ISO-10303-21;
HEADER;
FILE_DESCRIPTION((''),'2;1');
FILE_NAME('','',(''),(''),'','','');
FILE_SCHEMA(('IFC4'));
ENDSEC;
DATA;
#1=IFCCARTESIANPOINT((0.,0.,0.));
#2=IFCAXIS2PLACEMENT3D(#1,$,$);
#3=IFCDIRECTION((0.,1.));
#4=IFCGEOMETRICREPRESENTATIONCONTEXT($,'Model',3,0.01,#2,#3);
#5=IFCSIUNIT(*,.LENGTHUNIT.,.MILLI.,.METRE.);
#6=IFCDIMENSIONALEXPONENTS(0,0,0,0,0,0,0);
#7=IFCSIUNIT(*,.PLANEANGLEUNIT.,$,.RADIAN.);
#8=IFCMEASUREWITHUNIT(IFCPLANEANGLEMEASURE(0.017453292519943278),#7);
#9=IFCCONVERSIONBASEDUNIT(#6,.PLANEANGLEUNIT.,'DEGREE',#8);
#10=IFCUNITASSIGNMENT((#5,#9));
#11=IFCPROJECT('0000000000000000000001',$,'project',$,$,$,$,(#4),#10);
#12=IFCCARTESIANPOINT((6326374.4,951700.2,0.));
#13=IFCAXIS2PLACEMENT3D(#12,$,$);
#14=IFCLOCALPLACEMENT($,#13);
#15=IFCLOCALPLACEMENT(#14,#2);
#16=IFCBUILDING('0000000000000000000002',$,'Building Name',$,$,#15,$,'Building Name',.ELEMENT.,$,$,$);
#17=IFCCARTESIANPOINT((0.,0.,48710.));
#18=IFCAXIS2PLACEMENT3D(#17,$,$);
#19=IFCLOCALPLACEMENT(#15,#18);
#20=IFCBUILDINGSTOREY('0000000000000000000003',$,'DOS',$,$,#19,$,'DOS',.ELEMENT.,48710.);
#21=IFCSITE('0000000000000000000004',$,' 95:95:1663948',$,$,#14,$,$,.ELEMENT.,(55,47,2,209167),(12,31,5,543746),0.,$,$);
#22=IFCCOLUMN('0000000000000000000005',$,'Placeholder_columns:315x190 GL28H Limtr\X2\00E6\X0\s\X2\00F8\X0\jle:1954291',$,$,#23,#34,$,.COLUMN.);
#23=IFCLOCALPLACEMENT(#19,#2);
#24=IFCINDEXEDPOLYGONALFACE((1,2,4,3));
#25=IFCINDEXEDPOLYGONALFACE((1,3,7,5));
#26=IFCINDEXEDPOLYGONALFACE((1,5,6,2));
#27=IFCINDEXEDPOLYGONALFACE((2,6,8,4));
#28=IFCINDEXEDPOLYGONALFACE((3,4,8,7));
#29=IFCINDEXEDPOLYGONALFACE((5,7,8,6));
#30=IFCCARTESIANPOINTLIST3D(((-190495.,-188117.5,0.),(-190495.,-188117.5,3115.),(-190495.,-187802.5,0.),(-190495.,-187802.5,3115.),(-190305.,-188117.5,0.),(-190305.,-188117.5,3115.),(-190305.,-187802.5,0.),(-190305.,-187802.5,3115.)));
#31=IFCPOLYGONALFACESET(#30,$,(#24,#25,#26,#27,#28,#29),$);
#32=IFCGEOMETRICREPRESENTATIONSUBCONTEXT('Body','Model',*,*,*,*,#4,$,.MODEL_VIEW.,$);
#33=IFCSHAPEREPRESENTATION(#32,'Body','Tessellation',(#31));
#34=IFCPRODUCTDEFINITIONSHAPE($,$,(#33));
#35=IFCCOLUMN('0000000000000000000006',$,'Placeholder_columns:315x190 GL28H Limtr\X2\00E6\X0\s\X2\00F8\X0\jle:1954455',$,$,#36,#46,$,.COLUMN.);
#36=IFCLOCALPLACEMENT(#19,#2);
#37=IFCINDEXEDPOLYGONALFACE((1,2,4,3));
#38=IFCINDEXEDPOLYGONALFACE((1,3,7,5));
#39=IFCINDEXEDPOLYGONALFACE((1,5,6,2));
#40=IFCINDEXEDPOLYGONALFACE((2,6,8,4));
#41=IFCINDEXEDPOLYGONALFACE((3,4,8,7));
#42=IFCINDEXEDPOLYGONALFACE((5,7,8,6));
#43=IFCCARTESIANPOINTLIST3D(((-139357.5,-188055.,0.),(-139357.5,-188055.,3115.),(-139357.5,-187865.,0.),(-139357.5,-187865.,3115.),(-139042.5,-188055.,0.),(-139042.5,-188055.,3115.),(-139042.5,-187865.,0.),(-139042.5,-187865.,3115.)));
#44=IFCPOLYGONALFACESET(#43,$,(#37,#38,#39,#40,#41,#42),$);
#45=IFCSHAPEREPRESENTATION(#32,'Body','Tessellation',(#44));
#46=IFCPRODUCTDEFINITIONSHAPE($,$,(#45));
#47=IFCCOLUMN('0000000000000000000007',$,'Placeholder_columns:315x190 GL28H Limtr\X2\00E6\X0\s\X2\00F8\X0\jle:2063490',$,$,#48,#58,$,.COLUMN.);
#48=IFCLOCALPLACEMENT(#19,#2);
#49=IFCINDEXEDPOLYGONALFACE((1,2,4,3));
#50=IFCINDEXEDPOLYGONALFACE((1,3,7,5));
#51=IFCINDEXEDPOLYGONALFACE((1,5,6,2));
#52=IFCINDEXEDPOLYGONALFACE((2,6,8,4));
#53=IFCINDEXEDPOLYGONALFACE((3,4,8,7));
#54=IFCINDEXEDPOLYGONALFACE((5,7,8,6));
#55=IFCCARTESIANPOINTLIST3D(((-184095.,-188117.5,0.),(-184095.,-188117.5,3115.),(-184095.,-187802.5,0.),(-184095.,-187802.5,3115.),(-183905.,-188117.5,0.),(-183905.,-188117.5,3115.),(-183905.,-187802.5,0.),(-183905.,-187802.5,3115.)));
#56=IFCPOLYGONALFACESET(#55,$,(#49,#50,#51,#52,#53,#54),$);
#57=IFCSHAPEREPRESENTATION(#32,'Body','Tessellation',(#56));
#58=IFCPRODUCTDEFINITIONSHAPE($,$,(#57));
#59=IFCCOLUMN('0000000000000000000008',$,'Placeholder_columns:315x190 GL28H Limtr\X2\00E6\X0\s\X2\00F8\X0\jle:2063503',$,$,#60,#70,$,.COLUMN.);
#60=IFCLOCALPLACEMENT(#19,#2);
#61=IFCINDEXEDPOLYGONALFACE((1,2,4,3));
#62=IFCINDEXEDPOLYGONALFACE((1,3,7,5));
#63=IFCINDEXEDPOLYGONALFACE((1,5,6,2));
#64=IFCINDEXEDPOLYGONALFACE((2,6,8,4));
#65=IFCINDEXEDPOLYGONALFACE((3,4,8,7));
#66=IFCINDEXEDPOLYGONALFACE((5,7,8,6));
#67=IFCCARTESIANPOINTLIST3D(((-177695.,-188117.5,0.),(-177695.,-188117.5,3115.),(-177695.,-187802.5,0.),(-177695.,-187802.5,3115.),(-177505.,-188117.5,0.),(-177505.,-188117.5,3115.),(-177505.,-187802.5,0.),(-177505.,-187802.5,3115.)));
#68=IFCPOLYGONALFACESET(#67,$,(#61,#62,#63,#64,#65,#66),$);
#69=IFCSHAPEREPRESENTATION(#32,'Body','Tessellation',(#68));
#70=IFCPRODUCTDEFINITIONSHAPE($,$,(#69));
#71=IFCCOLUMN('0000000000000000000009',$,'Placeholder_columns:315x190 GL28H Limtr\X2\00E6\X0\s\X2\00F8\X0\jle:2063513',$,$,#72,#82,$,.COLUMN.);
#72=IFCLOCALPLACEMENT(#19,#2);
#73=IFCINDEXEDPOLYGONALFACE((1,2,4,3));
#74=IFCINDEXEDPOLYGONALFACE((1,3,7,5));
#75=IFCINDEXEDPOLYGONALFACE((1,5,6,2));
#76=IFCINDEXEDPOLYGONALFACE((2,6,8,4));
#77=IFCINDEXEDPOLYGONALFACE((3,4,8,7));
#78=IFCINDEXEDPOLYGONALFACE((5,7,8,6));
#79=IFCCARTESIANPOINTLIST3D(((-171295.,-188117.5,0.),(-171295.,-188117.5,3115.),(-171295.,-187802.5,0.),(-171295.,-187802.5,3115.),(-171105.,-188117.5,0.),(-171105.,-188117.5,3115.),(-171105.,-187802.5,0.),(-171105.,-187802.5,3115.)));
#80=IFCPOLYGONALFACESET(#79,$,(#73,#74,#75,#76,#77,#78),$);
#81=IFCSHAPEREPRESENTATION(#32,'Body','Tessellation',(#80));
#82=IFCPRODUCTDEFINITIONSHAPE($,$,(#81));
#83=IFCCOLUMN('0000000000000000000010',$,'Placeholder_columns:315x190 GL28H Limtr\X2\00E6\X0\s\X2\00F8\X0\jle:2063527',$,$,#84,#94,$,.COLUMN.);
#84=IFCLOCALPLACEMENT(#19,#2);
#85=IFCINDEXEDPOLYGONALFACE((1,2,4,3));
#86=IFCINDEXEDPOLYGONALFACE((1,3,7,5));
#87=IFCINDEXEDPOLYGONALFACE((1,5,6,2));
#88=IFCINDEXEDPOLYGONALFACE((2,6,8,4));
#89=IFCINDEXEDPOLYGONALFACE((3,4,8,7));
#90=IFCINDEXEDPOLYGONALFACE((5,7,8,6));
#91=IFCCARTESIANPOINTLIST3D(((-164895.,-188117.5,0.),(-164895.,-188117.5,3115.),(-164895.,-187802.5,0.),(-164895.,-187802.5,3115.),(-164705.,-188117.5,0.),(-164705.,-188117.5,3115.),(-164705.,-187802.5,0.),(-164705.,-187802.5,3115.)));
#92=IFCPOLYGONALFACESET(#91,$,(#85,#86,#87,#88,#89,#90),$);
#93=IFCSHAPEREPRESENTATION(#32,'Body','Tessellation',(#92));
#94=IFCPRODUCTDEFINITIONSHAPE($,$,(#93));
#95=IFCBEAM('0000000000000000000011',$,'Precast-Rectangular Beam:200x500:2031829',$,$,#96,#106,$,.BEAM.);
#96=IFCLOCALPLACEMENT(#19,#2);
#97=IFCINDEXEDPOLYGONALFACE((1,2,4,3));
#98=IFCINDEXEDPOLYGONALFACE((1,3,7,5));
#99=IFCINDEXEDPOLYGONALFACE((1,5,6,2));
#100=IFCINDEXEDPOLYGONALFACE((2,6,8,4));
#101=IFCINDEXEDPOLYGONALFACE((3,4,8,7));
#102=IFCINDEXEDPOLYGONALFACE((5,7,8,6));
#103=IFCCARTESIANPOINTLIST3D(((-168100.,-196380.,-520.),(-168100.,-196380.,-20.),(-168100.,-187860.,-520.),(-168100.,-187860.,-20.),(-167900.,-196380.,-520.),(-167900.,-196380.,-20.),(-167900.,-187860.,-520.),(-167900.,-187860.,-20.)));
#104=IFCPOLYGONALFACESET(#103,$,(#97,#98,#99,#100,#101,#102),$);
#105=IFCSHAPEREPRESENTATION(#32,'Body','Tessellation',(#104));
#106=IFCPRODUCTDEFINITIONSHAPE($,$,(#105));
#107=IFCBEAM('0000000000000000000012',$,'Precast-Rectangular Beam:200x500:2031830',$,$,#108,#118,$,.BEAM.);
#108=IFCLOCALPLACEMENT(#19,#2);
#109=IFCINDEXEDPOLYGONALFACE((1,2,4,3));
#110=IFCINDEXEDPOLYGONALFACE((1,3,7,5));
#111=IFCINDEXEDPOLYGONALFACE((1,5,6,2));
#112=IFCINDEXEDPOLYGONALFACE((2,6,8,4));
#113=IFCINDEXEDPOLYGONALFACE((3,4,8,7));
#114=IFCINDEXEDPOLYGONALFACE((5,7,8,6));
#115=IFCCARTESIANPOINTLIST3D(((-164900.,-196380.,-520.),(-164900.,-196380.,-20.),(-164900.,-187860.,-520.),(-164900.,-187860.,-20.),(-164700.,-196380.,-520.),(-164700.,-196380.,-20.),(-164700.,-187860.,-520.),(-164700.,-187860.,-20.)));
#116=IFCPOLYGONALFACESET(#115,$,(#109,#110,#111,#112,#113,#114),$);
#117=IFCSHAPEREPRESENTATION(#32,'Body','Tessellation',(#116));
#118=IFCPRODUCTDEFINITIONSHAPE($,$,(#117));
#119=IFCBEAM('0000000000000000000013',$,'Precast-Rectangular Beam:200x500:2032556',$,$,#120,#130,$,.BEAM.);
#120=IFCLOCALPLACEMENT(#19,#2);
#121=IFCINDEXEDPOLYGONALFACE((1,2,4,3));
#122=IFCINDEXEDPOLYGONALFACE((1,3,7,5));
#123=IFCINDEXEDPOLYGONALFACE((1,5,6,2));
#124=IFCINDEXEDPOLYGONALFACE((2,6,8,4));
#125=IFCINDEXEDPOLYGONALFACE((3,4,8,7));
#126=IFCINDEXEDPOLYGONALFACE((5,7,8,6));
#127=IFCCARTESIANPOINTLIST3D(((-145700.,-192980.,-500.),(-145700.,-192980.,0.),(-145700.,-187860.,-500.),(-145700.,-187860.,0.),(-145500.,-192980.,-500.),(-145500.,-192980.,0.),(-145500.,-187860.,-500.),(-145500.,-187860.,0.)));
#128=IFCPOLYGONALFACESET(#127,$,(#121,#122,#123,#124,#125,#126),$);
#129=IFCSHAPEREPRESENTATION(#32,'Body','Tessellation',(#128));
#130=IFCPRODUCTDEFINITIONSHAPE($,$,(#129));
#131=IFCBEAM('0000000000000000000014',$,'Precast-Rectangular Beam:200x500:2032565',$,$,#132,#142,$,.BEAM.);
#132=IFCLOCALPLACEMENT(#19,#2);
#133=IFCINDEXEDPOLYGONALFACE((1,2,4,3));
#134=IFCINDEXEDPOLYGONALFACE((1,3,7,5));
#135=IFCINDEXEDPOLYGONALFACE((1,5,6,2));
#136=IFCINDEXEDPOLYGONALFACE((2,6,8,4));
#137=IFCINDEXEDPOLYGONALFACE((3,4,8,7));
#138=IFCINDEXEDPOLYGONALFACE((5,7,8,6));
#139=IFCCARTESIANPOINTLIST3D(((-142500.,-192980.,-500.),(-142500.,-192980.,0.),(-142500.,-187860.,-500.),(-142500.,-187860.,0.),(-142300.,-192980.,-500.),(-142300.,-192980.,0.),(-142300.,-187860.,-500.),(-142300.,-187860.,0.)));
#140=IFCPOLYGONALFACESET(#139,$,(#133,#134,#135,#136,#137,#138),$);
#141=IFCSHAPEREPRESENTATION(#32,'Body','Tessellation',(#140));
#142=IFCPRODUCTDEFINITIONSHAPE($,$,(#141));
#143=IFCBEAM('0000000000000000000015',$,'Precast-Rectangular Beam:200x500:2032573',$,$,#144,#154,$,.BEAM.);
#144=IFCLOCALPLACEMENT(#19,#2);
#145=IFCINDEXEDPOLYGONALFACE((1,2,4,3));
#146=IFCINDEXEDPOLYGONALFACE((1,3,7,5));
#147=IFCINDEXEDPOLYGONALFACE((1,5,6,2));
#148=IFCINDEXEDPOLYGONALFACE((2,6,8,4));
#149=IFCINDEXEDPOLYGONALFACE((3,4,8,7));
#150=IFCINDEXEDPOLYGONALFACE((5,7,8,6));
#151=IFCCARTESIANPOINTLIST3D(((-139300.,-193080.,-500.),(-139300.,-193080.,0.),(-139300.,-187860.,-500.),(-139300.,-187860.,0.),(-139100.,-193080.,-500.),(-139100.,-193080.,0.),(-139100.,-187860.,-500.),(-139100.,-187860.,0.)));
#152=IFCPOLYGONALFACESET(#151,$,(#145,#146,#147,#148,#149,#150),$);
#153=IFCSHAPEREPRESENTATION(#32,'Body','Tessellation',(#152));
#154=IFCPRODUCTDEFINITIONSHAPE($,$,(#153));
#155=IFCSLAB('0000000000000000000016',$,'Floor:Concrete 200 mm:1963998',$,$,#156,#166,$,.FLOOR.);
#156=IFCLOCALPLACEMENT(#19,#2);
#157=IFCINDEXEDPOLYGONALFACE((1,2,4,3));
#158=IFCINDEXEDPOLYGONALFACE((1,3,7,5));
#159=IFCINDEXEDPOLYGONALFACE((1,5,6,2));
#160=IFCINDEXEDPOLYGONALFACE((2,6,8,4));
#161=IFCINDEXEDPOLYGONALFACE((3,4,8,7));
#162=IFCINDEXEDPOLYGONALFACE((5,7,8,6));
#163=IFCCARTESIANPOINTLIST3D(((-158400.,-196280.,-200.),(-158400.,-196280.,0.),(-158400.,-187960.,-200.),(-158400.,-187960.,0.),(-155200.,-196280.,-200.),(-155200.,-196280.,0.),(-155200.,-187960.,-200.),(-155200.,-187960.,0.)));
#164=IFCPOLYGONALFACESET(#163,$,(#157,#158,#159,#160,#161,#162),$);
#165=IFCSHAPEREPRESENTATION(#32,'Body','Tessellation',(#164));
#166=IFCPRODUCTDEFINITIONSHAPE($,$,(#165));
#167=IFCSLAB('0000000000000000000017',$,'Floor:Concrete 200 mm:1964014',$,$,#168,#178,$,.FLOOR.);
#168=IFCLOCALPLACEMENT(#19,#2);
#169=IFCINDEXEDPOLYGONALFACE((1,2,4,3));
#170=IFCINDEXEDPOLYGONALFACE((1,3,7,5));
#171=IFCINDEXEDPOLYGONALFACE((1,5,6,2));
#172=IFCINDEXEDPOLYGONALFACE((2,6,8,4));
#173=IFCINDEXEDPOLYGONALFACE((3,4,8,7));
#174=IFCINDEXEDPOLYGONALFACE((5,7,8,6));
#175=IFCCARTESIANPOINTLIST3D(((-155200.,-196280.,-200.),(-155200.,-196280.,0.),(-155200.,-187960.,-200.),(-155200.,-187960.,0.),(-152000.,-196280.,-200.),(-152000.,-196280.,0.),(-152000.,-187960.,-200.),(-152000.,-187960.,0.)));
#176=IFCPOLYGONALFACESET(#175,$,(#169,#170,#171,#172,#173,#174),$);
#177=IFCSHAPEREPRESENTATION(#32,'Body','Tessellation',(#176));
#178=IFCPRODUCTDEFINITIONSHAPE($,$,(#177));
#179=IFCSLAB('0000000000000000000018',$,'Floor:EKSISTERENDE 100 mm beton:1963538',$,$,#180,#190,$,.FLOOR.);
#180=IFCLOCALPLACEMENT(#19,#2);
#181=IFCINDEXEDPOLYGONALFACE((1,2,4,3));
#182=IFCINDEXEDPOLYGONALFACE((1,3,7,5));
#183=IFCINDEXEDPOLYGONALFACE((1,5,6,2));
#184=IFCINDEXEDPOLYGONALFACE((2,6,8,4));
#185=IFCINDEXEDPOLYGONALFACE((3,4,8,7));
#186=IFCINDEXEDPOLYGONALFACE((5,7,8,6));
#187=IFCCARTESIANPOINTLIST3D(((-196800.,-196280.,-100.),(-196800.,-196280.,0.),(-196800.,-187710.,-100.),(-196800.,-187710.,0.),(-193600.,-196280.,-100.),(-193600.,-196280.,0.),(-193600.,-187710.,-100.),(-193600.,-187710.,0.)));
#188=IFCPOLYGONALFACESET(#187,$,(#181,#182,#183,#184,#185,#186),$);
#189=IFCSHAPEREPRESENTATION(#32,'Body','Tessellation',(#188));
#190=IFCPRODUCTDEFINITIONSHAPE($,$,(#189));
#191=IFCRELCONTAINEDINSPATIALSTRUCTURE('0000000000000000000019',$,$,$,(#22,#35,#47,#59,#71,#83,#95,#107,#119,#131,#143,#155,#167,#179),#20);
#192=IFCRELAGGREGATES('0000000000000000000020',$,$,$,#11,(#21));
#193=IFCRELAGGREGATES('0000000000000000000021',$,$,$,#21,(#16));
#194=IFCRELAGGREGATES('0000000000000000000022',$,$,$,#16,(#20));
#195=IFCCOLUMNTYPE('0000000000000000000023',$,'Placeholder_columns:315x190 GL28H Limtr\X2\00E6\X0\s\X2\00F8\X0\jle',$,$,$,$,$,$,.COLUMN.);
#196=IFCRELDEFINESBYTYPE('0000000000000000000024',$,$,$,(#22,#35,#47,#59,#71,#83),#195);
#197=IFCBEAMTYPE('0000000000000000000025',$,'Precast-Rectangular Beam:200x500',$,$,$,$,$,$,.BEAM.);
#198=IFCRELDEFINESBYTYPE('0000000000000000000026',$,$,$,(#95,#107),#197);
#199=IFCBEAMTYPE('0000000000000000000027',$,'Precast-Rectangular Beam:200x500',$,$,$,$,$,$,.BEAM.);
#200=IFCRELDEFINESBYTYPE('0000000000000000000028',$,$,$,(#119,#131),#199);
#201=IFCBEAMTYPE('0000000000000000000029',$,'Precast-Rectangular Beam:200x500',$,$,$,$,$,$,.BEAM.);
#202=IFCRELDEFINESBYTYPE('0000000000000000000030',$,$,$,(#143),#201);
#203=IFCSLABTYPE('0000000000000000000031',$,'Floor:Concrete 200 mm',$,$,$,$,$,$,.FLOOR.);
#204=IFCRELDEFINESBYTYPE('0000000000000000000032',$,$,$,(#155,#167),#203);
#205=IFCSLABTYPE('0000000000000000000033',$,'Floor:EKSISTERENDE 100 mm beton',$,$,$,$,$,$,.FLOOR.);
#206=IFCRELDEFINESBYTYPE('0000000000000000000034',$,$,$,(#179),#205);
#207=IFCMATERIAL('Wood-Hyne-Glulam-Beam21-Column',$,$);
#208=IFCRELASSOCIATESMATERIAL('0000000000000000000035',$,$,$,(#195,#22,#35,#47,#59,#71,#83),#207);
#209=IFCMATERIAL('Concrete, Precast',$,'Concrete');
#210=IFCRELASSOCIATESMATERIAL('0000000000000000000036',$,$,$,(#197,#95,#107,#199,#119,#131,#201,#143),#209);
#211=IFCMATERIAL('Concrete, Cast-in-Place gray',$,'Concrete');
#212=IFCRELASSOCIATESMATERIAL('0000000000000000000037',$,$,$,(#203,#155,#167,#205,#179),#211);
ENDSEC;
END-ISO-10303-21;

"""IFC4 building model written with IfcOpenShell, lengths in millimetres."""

from ifc_helpers import new_model, entity, si_unit, converted_unit, direction, frame, origin, place, context, subcontext, project, spatial, indexed_curve, outline, extrude, source, transform, mapped, material, type_object, type_shapes, element, save


model = new_model("IFC4")

# Units and contexts
model_context = context("Model", 3, precision=0.01, world=origin(), true_north=direction((0.0, 1.0)))
body_context = subcontext(model_context, "Body", "Model", "MODEL_VIEW")
ifc_project = project(units=[si_unit("LENGTHUNIT", "METRE", prefix="MILLI"), converted_unit("PLANEANGLEUNIT", "DEGREE", entity("IfcPlaneAngleMeasure", 0.017453292519943278), si_unit("PLANEANGLEUNIT", "RADIAN"), dimensions=[0, 0, 0, 0, 0, 0, 0])], contexts=[model_context])

# Site, building, storey
site_placement = place(None, frame((6326374.4, 951700.2, 0.0)))
site = spatial("IfcSite", under=ifc_project, at=site_placement, Name=" 95:95:1663948", CompositionType="ELEMENT", RefLatitude=(55, 47, 2, 209167), RefLongitude=(12, 31, 5, 543746), RefElevation=0.0)
building_placement = place(site_placement, origin())
building = spatial("IfcBuilding", under=site, at=building_placement, Name="Building Name", LongName="Building Name", CompositionType="ELEMENT")
storey_placement = place(building_placement, frame((0.0, 0.0, 48710.0)))
storey = spatial("IfcBuildingStorey", under=building, at=storey_placement, Name="DOS", LongName="DOS", CompositionType="ELEMENT", Elevation=48710.0)

# Columns
ifc_material_1 = material(Name="Wood-Hyne-Glulam-Beam21-Column")
column_type = type_object("IfcColumnType", Name="Placeholder_columns:315x190 GL28H Limtræsøjle", PredefinedType="COLUMN", material=ifc_material_1)
shared_shape_1 = source(origin(), body_context, "Body", "SweptSolid", [
    extrude(outline(indexed_curve([(-157.5, -95.0), (157.5, -95.0), (157.5, 95.0), (-157.5, 95.0), (-157.5, -95.0)], self_intersect=False)), frame((0.0, 0.0, 48710.0), z_axis=(0.0, 0.0, 1.0), x_axis=(-1.0, 0.0, 0.0)), (0.0, 0.0, 1.0), 3115.0),
])
type_shapes(column_type, [shared_shape_1])
column_1_placement = place(storey_placement, frame((-190400.0, -187960.0, -48710.0), z_axis=(0.0, 0.0, 1.0), x_axis=(0.0, -1.0, 0.0)))
element("IfcColumn", 1, at=column_1_placement, inside=storey, type_object=column_type, material=ifc_material_1, Name="Placeholder_columns:315x190 GL28H Limtræsøjle:1954291", PredefinedType="COLUMN", context=body_context, shape_type="MappedRepresentation", body=[
    mapped(shared_shape_1, transform((0.0, 0.0, 0.0), scale=1.0)),
])
column_2_placement = place(storey_placement, frame((-139200.0, -187960.0, -48710.0)))
element("IfcColumn", 2, at=column_2_placement, inside=storey, type_object=column_type, material=ifc_material_1, Name="Placeholder_columns:315x190 GL28H Limtræsøjle:1954455", PredefinedType="COLUMN", context=body_context, shape_type="MappedRepresentation", body=[
    mapped(shared_shape_1, transform((0.0, 0.0, 0.0), scale=1.0)),
])
for number, where, z_axis, x_axis, name in (
    (3, (-184000.0, -187960.0, -48710.0), (0.0, 0.0, 1.0), (0.0, -1.0, 0.0), "Placeholder_columns:315x190 GL28H Limtræsøjle:2063490"),
    (4, (-177600.0, -187960.0, -48710.0), (0.0, 0.0, 1.0), (0.0, -1.0, 0.0), "Placeholder_columns:315x190 GL28H Limtræsøjle:2063503"),
    (5, (-171200.0, -187960.0, -48710.0), (0.0, 0.0, 1.0), (0.0, -1.0, 0.0), "Placeholder_columns:315x190 GL28H Limtræsøjle:2063513"),
    (6, (-164800.0, -187960.0, -48710.0), (0.0, 0.0, 1.0), (0.0, -1.0, 0.0), "Placeholder_columns:315x190 GL28H Limtræsøjle:2063527"),
):
    element("IfcColumn", number, at=place(storey_placement, frame(where, z_axis=z_axis, x_axis=x_axis)), inside=storey, type_object=column_type, material=ifc_material_1, Name=name, PredefinedType="COLUMN", context=body_context, shape_type="MappedRepresentation", body=[
        mapped(shared_shape_1, transform((0.0, 0.0, 0.0), scale=1.0)),
    ])

# Beams
ifc_material_2 = material(Name="Concrete, Precast", Category="Concrete")
beam_type_1 = type_object("IfcBeamType", Name="Precast-Rectangular Beam:200x500", PredefinedType="BEAM", material=ifc_material_2)
shared_shape_2 = source(origin(), body_context, "Body", "SweptSolid", [
    extrude(outline(indexed_curve([(-4260.0, -100.0), (4260.0, -100.0), (4260.0, 100.0), (-4260.0, 100.0), (-4260.0, -100.0)], self_intersect=False)), frame((3.6, 0.0, -250.0), z_axis=(0.0, 0.0, 1.0), x_axis=(-1.0, 0.0, 0.0)), (0.0, 0.0, 1.0), 500.0),
])
type_shapes(beam_type_1, [shared_shape_2])
for number, where, z_axis, x_axis, name in (
    (7, (-168000.0, -192116.4, -270.0), (0.0, 0.0, 1.0), (0.0, -1.0, 0.0), "Precast-Rectangular Beam:200x500:2031829"),
    (8, (-164800.0, -192116.4, -270.0), (0.0, 0.0, 1.0), (0.0, -1.0, 0.0), "Precast-Rectangular Beam:200x500:2031830"),
):
    element("IfcBeam", number, at=place(storey_placement, frame(where, z_axis=z_axis, x_axis=x_axis)), inside=storey, type_object=beam_type_1, material=ifc_material_2, Name=name, PredefinedType="BEAM", context=body_context, shape_type="MappedRepresentation", body=[
        mapped(shared_shape_2, transform((0.0, 0.0, 0.0), scale=1.0)),
    ])
beam_type_2 = type_object("IfcBeamType", Name="Precast-Rectangular Beam:200x500", PredefinedType="BEAM", material=ifc_material_2)
shared_shape_3 = source(origin(), body_context, "Body", "SweptSolid", [
    extrude(outline(indexed_curve([(-2560.0, -100.0), (2560.0, -100.0), (2560.0, 100.0), (-2560.0, 100.0), (-2560.0, -100.0)], self_intersect=False)), frame((-96.4, 0.0, -250.0), z_axis=(0.0, 0.0, 1.0), x_axis=(-1.0, 0.0, 0.0)), (0.0, 0.0, 1.0), 500.0),
])
type_shapes(beam_type_2, [shared_shape_3])
for number, where, z_axis, x_axis, name in (
    (9, (-145600.0, -190516.4, -250.0), (0.0, 0.0, 1.0), (0.0, -1.0, 0.0), "Precast-Rectangular Beam:200x500:2032556"),
    (10, (-142400.0, -190516.4, -250.0), (0.0, 0.0, 1.0), (0.0, -1.0, 0.0), "Precast-Rectangular Beam:200x500:2032565"),
):
    element("IfcBeam", number, at=place(storey_placement, frame(where, z_axis=z_axis, x_axis=x_axis)), inside=storey, type_object=beam_type_2, material=ifc_material_2, Name=name, PredefinedType="BEAM", context=body_context, shape_type="MappedRepresentation", body=[
        mapped(shared_shape_3, transform((0.0, 0.0, 0.0), scale=1.0)),
    ])
beam_type_3 = type_object("IfcBeamType", Name="Precast-Rectangular Beam:200x500", PredefinedType="BEAM", material=ifc_material_2)
shared_shape_4 = source(origin(), body_context, "Body", "SweptSolid", [
    extrude(outline(indexed_curve([(-2610.0, -100.0), (2610.0, -100.0), (2610.0, 100.0), (-2610.0, 100.0), (-2610.0, -100.0)], self_intersect=False)), frame((-46.4, 0.0, -250.0), z_axis=(0.0, 0.0, 1.0), x_axis=(-1.0, 0.0, 0.0)), (0.0, 0.0, 1.0), 500.0),
])
type_shapes(beam_type_3, [shared_shape_4])
beam_placement = place(storey_placement, frame((-139200.0, -190516.4, -250.0), z_axis=(0.0, 0.0, 1.0), x_axis=(0.0, -1.0, 0.0)))
element("IfcBeam", 11, at=beam_placement, inside=storey, type_object=beam_type_3, material=ifc_material_2, Name="Precast-Rectangular Beam:200x500:2032573", PredefinedType="BEAM", context=body_context, shape_type="MappedRepresentation", body=[
    mapped(shared_shape_4, transform((0.0, 0.0, 0.0), scale=1.0)),
])

# Slabs
ifc_material_3 = material(Name="Concrete, Cast-in-Place gray", Category="Concrete")
slab_type_1 = type_object("IfcSlabType", Name="Floor:Concrete 200 mm", PredefinedType="FLOOR", material=ifc_material_3)
slab_1_placement = place(storey_placement, origin())
element("IfcSlab", 12, at=slab_1_placement, inside=storey, type_object=slab_type_1, material=ifc_material_3, Name="Floor:Concrete 200 mm:1963998", PredefinedType="FLOOR", context=body_context, shape_type="SweptSolid", body=[
    extrude(outline(indexed_curve([(-4160.0, -1600.0), (4160.0, -1600.0), (4160.0, 1600.0), (-4160.0, 1600.0), (-4160.0, -1600.0)], self_intersect=False)), frame((-156800.0, -192120.0, 0.0), z_axis=(0.0, 0.0, -1.0), x_axis=(0.0, 1.0, 0.0)), (0.0, 0.0, 1.0), 200.0),
])
slab_2_placement = place(storey_placement, origin())
element("IfcSlab", 13, at=slab_2_placement, inside=storey, type_object=slab_type_1, material=ifc_material_3, Name="Floor:Concrete 200 mm:1964014", PredefinedType="FLOOR", context=body_context, shape_type="SweptSolid", body=[
    extrude(outline(indexed_curve([(-4160.0, -1600.0), (4160.0, -1600.0), (4160.0, 1600.0), (-4160.0, 1600.0), (-4160.0, -1600.0)], self_intersect=False)), frame((-153600.0, -192120.0, 0.0), z_axis=(0.0, 0.0, -1.0), x_axis=(0.0, 1.0, 0.0)), (0.0, 0.0, 1.0), 200.0),
])
slab_type_2 = type_object("IfcSlabType", Name="Floor:EKSISTERENDE 100 mm beton", PredefinedType="FLOOR", material=ifc_material_3)
for number, where, name in (
    (14, (0.0, 0.0, 0.0), "Floor:EKSISTERENDE 100 mm beton:1963538"),
):
    element("IfcSlab", number, at=place(storey_placement, frame(where)), inside=storey, type_object=slab_type_2, material=ifc_material_3, Name=name, PredefinedType="FLOOR", context=body_context, shape_type="SweptSolid", body=[
        extrude(outline(indexed_curve([(-4285.0, -1600.0), (4285.0, -1600.0), (4285.0, 1600.0), (-4285.0, 1600.0), (-4285.0, -1600.0)], self_intersect=False)), frame((-195200.0, -191995.0, 0.0), z_axis=(0.0, 0.0, -1.0), x_axis=(0.0, 1.0, 0.0)), (0.0, 0.0, 1.0), 100.0),
    ])

save(model, "model.ifc")
